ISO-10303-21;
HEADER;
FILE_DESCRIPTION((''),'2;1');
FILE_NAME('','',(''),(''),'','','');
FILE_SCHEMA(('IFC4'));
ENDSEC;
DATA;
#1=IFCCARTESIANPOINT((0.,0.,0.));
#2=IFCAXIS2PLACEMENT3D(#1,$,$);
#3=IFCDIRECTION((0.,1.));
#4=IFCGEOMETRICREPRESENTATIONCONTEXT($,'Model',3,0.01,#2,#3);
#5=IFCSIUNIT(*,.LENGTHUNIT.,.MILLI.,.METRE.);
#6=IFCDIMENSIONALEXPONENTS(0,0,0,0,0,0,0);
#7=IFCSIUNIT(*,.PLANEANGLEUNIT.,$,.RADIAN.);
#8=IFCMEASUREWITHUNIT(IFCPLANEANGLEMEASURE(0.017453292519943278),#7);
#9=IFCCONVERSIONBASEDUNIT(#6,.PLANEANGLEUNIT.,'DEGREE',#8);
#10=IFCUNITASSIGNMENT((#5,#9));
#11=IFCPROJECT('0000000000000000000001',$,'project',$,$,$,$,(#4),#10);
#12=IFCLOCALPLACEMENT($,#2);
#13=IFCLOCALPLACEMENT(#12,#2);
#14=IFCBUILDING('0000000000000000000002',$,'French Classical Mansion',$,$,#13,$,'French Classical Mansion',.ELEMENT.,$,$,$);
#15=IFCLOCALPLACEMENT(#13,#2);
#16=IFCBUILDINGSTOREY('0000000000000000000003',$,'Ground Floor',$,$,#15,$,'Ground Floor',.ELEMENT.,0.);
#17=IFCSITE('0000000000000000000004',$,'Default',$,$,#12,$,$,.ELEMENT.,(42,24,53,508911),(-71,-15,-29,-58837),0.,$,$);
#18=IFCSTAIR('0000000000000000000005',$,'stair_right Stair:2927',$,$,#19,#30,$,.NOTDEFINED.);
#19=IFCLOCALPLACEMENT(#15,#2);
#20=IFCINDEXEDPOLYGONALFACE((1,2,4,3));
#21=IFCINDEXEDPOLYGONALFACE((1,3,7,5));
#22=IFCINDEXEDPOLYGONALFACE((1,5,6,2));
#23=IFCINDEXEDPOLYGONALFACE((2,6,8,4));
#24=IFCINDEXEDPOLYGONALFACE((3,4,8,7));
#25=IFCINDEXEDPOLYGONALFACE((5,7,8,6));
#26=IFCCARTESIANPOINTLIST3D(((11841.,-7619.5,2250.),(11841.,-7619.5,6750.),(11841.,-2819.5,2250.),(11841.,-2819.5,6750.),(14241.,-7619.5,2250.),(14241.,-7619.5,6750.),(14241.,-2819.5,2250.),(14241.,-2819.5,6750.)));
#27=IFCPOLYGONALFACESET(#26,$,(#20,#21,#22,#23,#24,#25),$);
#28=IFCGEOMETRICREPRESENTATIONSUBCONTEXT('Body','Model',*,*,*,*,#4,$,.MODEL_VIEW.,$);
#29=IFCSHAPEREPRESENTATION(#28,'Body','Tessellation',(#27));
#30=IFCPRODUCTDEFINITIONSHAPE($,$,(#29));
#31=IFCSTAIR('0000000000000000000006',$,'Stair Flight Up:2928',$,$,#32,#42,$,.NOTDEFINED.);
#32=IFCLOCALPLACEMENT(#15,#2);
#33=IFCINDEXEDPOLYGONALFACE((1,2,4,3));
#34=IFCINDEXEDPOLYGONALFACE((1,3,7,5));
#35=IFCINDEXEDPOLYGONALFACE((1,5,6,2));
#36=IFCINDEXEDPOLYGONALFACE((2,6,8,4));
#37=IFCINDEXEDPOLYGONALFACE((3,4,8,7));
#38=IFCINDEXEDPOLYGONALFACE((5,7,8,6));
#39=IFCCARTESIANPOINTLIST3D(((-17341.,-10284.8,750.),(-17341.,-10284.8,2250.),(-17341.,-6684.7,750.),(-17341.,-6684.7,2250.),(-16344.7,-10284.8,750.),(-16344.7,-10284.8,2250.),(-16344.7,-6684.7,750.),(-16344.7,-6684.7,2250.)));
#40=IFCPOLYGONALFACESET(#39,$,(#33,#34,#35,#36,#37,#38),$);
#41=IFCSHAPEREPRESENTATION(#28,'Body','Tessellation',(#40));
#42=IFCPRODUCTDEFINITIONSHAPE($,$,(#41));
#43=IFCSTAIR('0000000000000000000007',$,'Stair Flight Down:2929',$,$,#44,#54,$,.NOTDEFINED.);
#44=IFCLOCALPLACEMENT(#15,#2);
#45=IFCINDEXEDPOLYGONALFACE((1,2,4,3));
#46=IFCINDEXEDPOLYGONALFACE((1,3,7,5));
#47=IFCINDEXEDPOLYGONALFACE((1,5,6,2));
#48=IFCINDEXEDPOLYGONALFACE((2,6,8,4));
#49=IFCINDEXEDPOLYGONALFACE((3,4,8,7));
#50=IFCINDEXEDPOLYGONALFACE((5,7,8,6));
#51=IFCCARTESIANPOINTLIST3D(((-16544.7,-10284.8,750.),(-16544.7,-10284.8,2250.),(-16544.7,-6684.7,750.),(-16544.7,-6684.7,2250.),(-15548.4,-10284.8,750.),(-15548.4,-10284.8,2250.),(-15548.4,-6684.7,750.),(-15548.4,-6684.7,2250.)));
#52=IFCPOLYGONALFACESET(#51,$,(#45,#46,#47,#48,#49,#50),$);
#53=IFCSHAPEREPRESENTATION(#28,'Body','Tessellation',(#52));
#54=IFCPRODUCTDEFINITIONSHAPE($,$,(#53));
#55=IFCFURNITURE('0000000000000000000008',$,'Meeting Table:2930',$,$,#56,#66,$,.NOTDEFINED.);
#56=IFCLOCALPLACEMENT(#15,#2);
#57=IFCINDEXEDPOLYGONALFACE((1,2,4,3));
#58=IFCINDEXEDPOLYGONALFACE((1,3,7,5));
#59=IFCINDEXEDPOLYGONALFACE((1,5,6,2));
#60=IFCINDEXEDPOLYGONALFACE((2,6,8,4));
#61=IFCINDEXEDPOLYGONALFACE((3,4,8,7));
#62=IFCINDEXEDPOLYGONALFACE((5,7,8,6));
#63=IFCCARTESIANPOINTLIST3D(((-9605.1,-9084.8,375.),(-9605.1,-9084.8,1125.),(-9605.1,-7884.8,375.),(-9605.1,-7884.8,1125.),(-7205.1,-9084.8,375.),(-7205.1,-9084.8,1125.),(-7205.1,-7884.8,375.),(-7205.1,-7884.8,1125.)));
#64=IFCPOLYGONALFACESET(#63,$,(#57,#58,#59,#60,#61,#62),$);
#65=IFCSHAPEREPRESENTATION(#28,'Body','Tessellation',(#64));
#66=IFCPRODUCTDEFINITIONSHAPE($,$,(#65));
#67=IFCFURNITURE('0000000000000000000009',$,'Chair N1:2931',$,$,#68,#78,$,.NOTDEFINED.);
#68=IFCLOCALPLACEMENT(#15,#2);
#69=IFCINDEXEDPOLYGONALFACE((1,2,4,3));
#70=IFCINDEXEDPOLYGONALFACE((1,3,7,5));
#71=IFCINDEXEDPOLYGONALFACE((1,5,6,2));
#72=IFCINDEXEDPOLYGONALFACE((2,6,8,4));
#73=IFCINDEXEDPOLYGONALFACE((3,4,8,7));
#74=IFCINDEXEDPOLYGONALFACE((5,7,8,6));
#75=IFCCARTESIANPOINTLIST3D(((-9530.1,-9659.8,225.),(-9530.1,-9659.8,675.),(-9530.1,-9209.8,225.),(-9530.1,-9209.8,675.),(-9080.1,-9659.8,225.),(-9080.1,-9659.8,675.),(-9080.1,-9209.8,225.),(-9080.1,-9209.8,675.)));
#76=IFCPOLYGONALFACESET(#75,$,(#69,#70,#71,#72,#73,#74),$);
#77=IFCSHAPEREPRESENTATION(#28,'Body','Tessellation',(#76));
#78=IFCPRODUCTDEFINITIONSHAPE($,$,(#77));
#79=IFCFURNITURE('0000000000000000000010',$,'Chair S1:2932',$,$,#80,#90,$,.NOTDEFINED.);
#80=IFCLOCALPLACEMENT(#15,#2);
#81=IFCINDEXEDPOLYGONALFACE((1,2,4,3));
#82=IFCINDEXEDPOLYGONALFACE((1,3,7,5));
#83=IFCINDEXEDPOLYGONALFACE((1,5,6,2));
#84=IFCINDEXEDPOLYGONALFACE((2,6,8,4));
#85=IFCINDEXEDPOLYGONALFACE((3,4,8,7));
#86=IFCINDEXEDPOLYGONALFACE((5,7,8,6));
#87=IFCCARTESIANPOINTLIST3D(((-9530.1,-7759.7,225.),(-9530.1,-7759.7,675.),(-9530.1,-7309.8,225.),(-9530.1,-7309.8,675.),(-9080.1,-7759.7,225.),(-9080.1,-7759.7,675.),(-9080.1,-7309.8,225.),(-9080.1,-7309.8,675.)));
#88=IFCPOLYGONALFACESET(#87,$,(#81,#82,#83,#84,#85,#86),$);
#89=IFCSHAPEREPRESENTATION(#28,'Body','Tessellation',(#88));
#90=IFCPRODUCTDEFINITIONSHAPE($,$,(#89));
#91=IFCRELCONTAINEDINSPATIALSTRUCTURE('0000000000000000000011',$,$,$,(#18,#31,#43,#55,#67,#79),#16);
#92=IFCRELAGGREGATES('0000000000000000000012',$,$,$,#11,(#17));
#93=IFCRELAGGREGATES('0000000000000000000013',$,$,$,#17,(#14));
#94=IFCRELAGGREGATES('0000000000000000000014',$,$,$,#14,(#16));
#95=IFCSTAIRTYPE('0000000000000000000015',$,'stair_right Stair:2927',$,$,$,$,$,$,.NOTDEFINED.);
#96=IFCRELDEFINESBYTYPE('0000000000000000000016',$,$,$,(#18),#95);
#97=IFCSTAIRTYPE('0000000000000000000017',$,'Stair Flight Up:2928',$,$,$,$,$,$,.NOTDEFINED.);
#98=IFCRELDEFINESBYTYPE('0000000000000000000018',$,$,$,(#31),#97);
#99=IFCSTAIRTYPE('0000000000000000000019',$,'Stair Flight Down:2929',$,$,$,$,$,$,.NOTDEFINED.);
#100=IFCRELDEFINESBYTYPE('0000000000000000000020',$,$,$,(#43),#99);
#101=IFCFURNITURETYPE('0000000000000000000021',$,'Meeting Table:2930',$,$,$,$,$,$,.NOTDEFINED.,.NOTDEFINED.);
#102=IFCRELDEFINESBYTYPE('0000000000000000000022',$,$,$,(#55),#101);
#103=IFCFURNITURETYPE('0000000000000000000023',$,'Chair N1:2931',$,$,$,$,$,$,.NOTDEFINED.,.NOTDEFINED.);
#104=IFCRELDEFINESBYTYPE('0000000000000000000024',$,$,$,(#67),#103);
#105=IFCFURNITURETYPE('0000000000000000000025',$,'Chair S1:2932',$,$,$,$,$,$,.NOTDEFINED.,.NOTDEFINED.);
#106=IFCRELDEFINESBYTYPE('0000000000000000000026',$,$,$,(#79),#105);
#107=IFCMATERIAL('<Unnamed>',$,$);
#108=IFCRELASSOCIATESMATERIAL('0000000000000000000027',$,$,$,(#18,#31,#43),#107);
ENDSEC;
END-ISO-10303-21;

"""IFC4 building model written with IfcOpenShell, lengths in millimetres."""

from ifc_helpers import new_model, entity, si_unit, converted_unit, direction, frame, frame_2d, origin, origin_2d_with_axis, place, context, subcontext, project, spatial, rectangle, extrude, material, type_object, element, save


model = new_model("IFC4")

# Units and contexts
model_context = context("Model", 3, precision=0.01, world=origin(), true_north=direction((0.0, 1.0)))
body_context = subcontext(model_context, "Body", "Model", "MODEL_VIEW")
ifc_project = project(units=[si_unit("LENGTHUNIT", "METRE", prefix="MILLI"), converted_unit("PLANEANGLEUNIT", "DEGREE", entity("IfcPlaneAngleMeasure", 0.017453292519943278), si_unit("PLANEANGLEUNIT", "RADIAN"), dimensions=[0, 0, 0, 0, 0, 0, 0])], contexts=[model_context])

# Site, building, storey
site_placement = place(None, origin())
site = spatial("IfcSite", under=ifc_project, at=site_placement, Name="Default", CompositionType="ELEMENT", RefLatitude=(42, 24, 53, 508911), RefLongitude=(-71, -15, -29, -58837), RefElevation=0.0)
building_placement = place(site_placement, origin())
building = spatial("IfcBuilding", under=site, at=building_placement, Name="French Classical Mansion", LongName="French Classical Mansion", CompositionType="ELEMENT")
storey_placement = place(building_placement, origin())
storey = spatial("IfcBuildingStorey", under=building, at=storey_placement, Name="Ground Floor", LongName="Ground Floor", CompositionType="ELEMENT", Elevation=0.0)

# Shared definitions
ifc_material_1 = material(Name="<Unnamed>")

# Stairs
stair_type_1 = type_object("IfcStairType", Name="stair_right Stair:2927", PredefinedType="NOTDEFINED")
stair_1_placement = place(storey_placement, origin())
element("IfcStair", 1, at=stair_1_placement, inside=storey, type_object=stair_type_1, material=ifc_material_1, Name="stair_right Stair:2927", PredefinedType="NOTDEFINED", context=body_context, shape_type="SweptSolid", body=[
    extrude(rectangle(XDim=2400.0, YDim=4800.0, at=origin_2d_with_axis()), frame((13041.0, -5219.5, 2250.0)), (0.0, 0.0, 1.0), 4500.0),
])
stair_type_2 = type_object("IfcStairType", Name="Stair Flight Up:2928", PredefinedType="NOTDEFINED")
stair_2_placement = place(storey_placement, origin())
element("IfcStair", 2, at=stair_2_placement, inside=storey, type_object=stair_type_2, material=ifc_material_1, Name="Stair Flight Up:2928", PredefinedType="NOTDEFINED", context=body_context, shape_type="SweptSolid", body=[
    extrude(rectangle(XDim=996.3, YDim=3600.0, at=frame_2d((0.0, 0.0), x_axis=(1.0, 0.0))), frame((-16842.8, -8484.8, 750.0)), (0.0, 0.0, 1.0), 1500.0),
])
stair_type_3 = type_object("IfcStairType", Name="Stair Flight Down:2929", PredefinedType="NOTDEFINED")
stair_3_placement = place(storey_placement, origin())
element("IfcStair", 3, at=stair_3_placement, inside=storey, type_object=stair_type_3, material=ifc_material_1, Name="Stair Flight Down:2929", PredefinedType="NOTDEFINED", context=body_context, shape_type="SweptSolid", body=[
    extrude(rectangle(XDim=996.3, YDim=3600.0, at=frame_2d((0.0, 0.0), x_axis=(1.0, 0.0))), frame((-16046.5, -8484.8, 750.0)), (0.0, 0.0, 1.0), 1500.0),
])

# Furniture
furniture_type_1 = type_object("IfcFurnitureType", Name="Meeting Table:2930", PredefinedType="NOTDEFINED")
furniture_1_placement = place(storey_placement, origin())
element("IfcFurniture", 4, at=furniture_1_placement, inside=storey, type_object=furniture_type_1, Name="Meeting Table:2930", PredefinedType="NOTDEFINED", context=body_context, shape_type="SweptSolid", body=[
    extrude(rectangle(XDim=2400.0, YDim=1200.0, at=origin_2d_with_axis()), frame((-8405.1, -8484.8, 375.0)), (0.0, 0.0, 1.0), 750.0),
])
furniture_type_2 = type_object("IfcFurnitureType", Name="Chair N1:2931", PredefinedType="NOTDEFINED")
furniture_2_placement = place(storey_placement, origin())
element("IfcFurniture", 5, at=furniture_2_placement, inside=storey, type_object=furniture_type_2, Name="Chair N1:2931", PredefinedType="NOTDEFINED", context=body_context, shape_type="SweptSolid", body=[
    extrude(rectangle(XDim=450.0, YDim=450.0, at=frame_2d((0.0, 0.0), x_axis=(1.0, 0.0))), frame((-9305.1, -9434.8, 225.0)), (0.0, 0.0, 1.0), 450.0),
])
furniture_type_3 = type_object("IfcFurnitureType", Name="Chair S1:2932", PredefinedType="NOTDEFINED")
furniture_3_placement = place(storey_placement, origin())
element("IfcFurniture", 6, at=furniture_3_placement, inside=storey, type_object=furniture_type_3, Name="Chair S1:2932", PredefinedType="NOTDEFINED", context=body_context, shape_type="SweptSolid", body=[
    extrude(rectangle(XDim=450.0, YDim=450.0, at=origin_2d_with_axis()), frame((-9305.1, -7534.8, 225.0)), (0.0, 0.0, 1.0), 450.0),
])

save(model, "model.ifc")
